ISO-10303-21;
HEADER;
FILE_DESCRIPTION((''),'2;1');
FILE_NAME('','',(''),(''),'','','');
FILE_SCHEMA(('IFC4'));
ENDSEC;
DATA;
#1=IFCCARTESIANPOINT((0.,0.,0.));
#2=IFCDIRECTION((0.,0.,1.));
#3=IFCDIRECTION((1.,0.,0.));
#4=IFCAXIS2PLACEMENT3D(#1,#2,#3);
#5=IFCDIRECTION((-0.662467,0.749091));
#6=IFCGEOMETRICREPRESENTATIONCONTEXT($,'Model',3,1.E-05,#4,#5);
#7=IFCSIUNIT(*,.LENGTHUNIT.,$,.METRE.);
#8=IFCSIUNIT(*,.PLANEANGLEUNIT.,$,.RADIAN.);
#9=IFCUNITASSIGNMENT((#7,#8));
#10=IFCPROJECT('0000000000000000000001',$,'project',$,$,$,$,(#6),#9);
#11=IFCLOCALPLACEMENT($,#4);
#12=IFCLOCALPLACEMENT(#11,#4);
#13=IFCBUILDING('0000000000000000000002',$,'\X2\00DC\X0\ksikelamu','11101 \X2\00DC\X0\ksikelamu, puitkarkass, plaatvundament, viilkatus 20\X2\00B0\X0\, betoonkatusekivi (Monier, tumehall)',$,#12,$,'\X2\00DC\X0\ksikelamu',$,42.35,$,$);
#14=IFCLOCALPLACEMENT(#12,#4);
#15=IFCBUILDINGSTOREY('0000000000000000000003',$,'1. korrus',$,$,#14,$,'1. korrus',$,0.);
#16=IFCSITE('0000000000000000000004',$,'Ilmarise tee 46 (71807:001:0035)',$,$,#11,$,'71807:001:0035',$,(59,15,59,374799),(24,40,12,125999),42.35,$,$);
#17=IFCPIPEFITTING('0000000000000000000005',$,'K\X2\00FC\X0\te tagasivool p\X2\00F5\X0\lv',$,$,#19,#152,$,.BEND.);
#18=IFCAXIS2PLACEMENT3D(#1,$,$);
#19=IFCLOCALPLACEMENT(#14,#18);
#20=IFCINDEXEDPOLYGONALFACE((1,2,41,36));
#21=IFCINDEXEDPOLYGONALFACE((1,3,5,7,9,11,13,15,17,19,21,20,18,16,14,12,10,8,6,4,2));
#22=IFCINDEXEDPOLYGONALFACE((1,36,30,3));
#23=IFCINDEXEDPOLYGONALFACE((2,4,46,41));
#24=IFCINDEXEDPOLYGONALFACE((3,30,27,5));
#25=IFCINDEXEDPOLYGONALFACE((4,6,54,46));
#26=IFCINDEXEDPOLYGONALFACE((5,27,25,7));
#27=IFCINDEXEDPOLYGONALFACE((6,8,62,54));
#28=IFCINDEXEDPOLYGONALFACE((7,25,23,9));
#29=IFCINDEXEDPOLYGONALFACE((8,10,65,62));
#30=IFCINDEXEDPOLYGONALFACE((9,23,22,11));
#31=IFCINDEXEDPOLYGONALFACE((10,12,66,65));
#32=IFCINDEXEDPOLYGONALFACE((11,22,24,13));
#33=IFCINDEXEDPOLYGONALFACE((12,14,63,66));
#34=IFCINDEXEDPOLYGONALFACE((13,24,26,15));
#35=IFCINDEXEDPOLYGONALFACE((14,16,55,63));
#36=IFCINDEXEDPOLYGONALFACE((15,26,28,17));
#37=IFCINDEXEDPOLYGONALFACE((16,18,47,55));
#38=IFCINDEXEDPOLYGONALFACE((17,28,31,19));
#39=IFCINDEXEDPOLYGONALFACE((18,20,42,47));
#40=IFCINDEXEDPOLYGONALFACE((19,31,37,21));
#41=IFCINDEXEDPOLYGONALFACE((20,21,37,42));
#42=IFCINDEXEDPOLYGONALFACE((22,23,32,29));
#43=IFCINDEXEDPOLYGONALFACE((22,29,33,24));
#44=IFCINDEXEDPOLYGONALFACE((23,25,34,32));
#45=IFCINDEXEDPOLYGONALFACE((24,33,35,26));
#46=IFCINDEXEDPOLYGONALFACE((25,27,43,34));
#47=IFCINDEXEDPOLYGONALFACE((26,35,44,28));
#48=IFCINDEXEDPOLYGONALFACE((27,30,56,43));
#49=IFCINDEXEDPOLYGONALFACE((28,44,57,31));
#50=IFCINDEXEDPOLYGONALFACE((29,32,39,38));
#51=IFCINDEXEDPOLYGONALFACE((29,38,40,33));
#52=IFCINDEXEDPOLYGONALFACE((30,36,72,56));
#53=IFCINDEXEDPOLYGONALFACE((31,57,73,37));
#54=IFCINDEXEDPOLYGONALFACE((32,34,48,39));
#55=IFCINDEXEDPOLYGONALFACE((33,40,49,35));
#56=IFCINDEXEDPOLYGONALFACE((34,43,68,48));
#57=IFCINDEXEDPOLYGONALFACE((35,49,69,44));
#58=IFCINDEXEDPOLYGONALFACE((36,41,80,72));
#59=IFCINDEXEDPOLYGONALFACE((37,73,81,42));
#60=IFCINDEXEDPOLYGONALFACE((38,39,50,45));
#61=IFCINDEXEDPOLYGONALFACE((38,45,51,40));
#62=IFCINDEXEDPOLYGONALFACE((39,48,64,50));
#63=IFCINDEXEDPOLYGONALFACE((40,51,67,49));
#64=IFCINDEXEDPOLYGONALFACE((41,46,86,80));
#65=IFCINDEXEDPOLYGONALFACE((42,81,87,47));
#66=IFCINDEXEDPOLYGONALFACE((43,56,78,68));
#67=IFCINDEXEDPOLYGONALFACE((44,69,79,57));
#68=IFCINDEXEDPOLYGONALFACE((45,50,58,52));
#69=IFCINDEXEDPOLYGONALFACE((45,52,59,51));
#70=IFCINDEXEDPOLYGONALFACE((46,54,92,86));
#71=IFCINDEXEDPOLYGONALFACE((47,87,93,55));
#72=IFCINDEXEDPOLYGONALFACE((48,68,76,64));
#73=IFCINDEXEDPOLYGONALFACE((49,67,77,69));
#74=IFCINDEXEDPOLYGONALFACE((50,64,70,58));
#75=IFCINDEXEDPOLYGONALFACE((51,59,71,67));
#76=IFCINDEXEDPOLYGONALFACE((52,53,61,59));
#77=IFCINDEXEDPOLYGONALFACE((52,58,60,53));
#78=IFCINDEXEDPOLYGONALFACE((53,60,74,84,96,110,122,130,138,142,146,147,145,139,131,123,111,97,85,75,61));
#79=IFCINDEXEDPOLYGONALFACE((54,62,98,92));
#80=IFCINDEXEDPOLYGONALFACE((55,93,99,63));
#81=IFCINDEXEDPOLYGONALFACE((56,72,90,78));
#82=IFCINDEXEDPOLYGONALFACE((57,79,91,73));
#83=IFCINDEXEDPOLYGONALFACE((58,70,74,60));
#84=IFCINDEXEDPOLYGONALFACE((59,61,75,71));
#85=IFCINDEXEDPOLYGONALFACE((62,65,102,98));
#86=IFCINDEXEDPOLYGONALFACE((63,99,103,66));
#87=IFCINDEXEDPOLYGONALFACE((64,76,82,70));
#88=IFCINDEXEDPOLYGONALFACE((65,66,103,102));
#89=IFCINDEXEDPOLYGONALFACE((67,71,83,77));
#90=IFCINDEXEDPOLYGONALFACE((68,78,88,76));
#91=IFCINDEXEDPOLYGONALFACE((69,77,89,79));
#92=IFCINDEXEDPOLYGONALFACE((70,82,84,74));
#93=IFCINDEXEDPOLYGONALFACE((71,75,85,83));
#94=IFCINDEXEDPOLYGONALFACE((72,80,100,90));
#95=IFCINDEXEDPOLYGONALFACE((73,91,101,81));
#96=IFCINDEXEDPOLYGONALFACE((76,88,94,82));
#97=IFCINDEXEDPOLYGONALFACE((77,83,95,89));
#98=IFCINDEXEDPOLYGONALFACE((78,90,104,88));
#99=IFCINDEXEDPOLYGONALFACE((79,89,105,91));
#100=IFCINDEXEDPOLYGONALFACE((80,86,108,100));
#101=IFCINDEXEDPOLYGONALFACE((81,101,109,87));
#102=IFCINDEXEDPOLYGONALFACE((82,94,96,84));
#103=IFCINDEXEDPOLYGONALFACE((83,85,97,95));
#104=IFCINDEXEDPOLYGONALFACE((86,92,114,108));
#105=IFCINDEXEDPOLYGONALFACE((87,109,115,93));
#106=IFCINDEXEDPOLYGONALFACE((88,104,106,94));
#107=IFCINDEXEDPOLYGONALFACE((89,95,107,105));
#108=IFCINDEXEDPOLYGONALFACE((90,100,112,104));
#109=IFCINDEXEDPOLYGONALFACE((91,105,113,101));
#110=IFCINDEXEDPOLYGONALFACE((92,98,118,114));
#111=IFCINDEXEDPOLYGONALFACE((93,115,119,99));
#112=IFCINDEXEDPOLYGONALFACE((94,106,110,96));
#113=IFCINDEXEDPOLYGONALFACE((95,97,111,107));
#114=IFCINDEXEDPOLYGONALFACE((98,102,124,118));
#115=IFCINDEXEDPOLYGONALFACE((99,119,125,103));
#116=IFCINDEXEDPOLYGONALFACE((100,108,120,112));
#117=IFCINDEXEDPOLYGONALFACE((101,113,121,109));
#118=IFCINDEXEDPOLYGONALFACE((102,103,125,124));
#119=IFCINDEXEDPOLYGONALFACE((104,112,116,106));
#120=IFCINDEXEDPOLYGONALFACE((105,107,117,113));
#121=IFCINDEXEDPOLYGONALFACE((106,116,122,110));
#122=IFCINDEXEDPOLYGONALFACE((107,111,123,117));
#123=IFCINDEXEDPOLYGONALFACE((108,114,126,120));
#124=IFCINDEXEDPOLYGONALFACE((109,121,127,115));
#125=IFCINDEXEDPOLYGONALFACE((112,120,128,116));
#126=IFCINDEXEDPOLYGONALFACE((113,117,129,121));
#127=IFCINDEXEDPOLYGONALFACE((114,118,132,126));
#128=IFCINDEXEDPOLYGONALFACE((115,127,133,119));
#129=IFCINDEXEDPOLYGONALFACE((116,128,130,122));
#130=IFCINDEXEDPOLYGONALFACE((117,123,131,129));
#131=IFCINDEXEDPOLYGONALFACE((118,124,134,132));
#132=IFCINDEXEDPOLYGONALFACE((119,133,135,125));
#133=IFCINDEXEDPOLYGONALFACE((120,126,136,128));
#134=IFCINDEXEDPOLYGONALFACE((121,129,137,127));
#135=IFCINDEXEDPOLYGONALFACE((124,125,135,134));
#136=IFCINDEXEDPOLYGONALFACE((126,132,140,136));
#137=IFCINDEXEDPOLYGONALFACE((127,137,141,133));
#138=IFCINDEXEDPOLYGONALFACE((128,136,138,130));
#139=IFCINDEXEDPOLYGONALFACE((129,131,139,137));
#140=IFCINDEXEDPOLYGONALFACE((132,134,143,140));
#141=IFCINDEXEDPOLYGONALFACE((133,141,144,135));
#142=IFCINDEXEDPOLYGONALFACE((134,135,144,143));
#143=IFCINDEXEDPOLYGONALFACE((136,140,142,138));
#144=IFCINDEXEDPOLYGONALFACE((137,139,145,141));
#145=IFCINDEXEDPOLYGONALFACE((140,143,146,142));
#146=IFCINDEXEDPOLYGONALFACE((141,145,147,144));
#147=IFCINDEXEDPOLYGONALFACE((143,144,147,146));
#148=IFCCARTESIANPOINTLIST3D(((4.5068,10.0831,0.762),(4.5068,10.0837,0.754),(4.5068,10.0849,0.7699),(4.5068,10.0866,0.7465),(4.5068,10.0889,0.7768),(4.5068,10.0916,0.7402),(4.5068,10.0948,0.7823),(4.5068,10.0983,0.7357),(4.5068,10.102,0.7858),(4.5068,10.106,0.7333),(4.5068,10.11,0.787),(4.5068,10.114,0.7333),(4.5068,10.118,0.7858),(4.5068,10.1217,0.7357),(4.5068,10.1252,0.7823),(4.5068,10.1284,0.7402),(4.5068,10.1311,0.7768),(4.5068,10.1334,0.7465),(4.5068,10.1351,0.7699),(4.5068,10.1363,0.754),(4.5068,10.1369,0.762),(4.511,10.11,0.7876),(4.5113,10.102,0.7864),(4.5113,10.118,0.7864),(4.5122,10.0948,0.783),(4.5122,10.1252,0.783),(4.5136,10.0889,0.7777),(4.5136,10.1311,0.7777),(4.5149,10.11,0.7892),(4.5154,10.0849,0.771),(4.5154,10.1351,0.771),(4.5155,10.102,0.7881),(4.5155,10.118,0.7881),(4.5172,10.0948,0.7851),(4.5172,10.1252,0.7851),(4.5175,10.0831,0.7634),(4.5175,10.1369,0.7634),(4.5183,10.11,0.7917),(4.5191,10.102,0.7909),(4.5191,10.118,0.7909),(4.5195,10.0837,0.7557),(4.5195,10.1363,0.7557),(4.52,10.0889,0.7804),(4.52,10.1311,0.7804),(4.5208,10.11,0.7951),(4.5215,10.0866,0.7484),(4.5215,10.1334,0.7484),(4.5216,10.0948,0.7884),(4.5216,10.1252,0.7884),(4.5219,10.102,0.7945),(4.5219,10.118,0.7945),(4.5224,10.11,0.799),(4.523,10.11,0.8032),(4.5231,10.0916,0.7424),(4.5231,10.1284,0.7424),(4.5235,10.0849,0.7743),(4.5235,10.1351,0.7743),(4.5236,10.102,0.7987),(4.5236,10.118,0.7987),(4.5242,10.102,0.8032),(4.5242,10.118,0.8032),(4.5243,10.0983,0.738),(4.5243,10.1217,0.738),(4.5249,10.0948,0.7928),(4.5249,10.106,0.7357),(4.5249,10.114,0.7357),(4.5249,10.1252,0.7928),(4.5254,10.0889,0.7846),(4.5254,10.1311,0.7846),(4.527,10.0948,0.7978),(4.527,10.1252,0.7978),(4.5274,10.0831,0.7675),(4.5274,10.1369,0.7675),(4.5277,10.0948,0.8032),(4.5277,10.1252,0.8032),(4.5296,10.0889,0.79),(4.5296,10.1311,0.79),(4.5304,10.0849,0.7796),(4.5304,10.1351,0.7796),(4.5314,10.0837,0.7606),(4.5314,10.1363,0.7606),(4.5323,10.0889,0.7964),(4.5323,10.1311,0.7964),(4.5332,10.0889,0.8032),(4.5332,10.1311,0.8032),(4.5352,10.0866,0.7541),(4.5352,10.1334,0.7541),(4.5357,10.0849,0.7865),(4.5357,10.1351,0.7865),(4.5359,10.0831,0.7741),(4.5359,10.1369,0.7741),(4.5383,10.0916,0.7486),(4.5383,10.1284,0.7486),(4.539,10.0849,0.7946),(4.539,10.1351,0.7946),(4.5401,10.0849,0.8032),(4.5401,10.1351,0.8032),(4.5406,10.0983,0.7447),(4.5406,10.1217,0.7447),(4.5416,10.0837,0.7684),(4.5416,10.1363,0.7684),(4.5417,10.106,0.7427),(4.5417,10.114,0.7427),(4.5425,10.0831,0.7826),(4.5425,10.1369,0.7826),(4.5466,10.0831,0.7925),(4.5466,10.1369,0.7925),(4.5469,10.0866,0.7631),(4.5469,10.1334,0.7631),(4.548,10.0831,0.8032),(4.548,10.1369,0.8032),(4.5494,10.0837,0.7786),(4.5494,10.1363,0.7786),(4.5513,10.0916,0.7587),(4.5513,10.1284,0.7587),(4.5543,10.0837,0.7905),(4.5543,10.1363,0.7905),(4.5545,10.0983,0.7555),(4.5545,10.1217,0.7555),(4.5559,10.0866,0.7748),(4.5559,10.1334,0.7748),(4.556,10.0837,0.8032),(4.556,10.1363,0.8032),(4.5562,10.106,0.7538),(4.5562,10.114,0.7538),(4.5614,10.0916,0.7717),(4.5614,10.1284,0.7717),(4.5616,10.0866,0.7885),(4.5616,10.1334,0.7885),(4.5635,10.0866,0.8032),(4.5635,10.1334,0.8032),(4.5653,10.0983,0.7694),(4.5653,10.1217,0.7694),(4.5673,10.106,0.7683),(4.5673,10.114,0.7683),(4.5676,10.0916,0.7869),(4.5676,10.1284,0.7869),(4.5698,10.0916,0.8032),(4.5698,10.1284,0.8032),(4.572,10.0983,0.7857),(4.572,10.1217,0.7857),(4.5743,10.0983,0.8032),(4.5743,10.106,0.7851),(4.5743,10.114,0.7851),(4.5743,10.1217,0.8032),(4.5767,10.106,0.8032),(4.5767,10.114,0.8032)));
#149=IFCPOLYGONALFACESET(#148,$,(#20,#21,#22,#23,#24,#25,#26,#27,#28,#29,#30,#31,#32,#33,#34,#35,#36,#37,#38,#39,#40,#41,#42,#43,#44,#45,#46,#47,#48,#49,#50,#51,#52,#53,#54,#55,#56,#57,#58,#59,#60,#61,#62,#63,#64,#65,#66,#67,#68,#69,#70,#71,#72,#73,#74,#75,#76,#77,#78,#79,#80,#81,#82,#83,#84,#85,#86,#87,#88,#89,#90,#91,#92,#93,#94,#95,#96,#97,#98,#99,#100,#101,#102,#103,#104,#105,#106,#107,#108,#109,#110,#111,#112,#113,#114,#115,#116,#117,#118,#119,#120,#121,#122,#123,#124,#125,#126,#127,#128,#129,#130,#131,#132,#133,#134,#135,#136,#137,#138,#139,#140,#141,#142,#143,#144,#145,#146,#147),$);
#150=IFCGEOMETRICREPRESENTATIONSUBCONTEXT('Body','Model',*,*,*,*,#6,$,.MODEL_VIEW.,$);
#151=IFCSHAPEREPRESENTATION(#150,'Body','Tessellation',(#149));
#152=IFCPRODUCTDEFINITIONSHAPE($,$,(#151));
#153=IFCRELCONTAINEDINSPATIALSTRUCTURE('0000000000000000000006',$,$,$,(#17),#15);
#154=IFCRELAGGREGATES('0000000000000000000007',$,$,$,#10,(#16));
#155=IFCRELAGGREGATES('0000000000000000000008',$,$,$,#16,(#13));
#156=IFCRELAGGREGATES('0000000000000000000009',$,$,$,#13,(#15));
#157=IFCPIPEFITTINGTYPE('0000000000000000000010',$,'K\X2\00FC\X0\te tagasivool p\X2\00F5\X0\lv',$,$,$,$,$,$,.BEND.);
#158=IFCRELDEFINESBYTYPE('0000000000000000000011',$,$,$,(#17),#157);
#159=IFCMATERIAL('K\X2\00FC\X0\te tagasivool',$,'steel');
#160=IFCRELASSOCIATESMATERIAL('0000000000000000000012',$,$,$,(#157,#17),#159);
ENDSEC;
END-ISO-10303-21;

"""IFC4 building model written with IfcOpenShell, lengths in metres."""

from ifc_helpers import new_model, entity, si_unit, direction, frame, origin_with_axes, place, context, subcontext, project, spatial, material, type_object, element, save


model = new_model("IFC4")

# Units and contexts
model_context = context("Model", 3, precision=1e-05, world=origin_with_axes(), true_north=direction((-0.662467, 0.749091)))
body_context = subcontext(model_context, "Body", "Model", "MODEL_VIEW")
ifc_project = project(units=[si_unit("LENGTHUNIT", "METRE"), si_unit("PLANEANGLEUNIT", "RADIAN")], contexts=[model_context])

# Site, building, storey
site_placement = place(None, origin_with_axes())
site = spatial("IfcSite", under=ifc_project, at=site_placement, Name="Ilmarise tee 46 (71807:001:0035)", LongName="71807:001:0035", RefLatitude=(59, 15, 59, 374799), RefLongitude=(24, 40, 12, 125999), RefElevation=42.35)
building_placement = place(site_placement, origin_with_axes())
building = spatial("IfcBuilding", under=site, at=building_placement, Name="Üksikelamu", Description="11101 Üksikelamu, puitkarkass, plaatvundament, viilkatus 20°, betoonkatusekivi (Monier, tumehall)", LongName="Üksikelamu", ElevationOfRefHeight=42.35)
storey_placement = place(building_placement, origin_with_axes())
storey = spatial("IfcBuildingStorey", under=building, at=storey_placement, Name="1. korrus", LongName="1. korrus", Elevation=0.0)

# Pipe fitting
ifc_material_1 = material(Name="Küte tagasivool", Category="steel")
pipe_fitting_type_1 = type_object("IfcPipeFittingType", Name="Küte tagasivool põlv", PredefinedType="BEND", material=ifc_material_1)
pipe_fitting_1_placement = place(storey_placement, frame((4.55, 10.11, 0.76), z_axis=(0.0, 0.0, 1.0), x_axis=(1.0, 0.0, 0.0)))
element("IfcPipeFitting", 1, at=pipe_fitting_1_placement, inside=storey, type_object=pipe_fitting_type_1, material=ifc_material_1, Name="Küte tagasivool põlv", PredefinedType="BEND", context=body_context, shape_type="SweptSolid", body=[
    entity("IfcRevolvedAreaSolid", entity("IfcCircleProfileDef", "AREA", None, None, 0.027), entity("IfcAxis2Placement3D", entity("IfcCartesianPoint", [-0.0432, 0.0, 0.0]), entity("IfcDirection", [1.0, 0.0, 0.0]), entity("IfcDirection", [0.0, 0.0, 1.0])), entity("IfcAxis1Placement", entity("IfcCartesianPoint", [0.0432, 0.0, 0.0]), entity("IfcDirection", [0.0, 1.0, 0.0])), 1.570796),
])

save(model, "model.ifc")
